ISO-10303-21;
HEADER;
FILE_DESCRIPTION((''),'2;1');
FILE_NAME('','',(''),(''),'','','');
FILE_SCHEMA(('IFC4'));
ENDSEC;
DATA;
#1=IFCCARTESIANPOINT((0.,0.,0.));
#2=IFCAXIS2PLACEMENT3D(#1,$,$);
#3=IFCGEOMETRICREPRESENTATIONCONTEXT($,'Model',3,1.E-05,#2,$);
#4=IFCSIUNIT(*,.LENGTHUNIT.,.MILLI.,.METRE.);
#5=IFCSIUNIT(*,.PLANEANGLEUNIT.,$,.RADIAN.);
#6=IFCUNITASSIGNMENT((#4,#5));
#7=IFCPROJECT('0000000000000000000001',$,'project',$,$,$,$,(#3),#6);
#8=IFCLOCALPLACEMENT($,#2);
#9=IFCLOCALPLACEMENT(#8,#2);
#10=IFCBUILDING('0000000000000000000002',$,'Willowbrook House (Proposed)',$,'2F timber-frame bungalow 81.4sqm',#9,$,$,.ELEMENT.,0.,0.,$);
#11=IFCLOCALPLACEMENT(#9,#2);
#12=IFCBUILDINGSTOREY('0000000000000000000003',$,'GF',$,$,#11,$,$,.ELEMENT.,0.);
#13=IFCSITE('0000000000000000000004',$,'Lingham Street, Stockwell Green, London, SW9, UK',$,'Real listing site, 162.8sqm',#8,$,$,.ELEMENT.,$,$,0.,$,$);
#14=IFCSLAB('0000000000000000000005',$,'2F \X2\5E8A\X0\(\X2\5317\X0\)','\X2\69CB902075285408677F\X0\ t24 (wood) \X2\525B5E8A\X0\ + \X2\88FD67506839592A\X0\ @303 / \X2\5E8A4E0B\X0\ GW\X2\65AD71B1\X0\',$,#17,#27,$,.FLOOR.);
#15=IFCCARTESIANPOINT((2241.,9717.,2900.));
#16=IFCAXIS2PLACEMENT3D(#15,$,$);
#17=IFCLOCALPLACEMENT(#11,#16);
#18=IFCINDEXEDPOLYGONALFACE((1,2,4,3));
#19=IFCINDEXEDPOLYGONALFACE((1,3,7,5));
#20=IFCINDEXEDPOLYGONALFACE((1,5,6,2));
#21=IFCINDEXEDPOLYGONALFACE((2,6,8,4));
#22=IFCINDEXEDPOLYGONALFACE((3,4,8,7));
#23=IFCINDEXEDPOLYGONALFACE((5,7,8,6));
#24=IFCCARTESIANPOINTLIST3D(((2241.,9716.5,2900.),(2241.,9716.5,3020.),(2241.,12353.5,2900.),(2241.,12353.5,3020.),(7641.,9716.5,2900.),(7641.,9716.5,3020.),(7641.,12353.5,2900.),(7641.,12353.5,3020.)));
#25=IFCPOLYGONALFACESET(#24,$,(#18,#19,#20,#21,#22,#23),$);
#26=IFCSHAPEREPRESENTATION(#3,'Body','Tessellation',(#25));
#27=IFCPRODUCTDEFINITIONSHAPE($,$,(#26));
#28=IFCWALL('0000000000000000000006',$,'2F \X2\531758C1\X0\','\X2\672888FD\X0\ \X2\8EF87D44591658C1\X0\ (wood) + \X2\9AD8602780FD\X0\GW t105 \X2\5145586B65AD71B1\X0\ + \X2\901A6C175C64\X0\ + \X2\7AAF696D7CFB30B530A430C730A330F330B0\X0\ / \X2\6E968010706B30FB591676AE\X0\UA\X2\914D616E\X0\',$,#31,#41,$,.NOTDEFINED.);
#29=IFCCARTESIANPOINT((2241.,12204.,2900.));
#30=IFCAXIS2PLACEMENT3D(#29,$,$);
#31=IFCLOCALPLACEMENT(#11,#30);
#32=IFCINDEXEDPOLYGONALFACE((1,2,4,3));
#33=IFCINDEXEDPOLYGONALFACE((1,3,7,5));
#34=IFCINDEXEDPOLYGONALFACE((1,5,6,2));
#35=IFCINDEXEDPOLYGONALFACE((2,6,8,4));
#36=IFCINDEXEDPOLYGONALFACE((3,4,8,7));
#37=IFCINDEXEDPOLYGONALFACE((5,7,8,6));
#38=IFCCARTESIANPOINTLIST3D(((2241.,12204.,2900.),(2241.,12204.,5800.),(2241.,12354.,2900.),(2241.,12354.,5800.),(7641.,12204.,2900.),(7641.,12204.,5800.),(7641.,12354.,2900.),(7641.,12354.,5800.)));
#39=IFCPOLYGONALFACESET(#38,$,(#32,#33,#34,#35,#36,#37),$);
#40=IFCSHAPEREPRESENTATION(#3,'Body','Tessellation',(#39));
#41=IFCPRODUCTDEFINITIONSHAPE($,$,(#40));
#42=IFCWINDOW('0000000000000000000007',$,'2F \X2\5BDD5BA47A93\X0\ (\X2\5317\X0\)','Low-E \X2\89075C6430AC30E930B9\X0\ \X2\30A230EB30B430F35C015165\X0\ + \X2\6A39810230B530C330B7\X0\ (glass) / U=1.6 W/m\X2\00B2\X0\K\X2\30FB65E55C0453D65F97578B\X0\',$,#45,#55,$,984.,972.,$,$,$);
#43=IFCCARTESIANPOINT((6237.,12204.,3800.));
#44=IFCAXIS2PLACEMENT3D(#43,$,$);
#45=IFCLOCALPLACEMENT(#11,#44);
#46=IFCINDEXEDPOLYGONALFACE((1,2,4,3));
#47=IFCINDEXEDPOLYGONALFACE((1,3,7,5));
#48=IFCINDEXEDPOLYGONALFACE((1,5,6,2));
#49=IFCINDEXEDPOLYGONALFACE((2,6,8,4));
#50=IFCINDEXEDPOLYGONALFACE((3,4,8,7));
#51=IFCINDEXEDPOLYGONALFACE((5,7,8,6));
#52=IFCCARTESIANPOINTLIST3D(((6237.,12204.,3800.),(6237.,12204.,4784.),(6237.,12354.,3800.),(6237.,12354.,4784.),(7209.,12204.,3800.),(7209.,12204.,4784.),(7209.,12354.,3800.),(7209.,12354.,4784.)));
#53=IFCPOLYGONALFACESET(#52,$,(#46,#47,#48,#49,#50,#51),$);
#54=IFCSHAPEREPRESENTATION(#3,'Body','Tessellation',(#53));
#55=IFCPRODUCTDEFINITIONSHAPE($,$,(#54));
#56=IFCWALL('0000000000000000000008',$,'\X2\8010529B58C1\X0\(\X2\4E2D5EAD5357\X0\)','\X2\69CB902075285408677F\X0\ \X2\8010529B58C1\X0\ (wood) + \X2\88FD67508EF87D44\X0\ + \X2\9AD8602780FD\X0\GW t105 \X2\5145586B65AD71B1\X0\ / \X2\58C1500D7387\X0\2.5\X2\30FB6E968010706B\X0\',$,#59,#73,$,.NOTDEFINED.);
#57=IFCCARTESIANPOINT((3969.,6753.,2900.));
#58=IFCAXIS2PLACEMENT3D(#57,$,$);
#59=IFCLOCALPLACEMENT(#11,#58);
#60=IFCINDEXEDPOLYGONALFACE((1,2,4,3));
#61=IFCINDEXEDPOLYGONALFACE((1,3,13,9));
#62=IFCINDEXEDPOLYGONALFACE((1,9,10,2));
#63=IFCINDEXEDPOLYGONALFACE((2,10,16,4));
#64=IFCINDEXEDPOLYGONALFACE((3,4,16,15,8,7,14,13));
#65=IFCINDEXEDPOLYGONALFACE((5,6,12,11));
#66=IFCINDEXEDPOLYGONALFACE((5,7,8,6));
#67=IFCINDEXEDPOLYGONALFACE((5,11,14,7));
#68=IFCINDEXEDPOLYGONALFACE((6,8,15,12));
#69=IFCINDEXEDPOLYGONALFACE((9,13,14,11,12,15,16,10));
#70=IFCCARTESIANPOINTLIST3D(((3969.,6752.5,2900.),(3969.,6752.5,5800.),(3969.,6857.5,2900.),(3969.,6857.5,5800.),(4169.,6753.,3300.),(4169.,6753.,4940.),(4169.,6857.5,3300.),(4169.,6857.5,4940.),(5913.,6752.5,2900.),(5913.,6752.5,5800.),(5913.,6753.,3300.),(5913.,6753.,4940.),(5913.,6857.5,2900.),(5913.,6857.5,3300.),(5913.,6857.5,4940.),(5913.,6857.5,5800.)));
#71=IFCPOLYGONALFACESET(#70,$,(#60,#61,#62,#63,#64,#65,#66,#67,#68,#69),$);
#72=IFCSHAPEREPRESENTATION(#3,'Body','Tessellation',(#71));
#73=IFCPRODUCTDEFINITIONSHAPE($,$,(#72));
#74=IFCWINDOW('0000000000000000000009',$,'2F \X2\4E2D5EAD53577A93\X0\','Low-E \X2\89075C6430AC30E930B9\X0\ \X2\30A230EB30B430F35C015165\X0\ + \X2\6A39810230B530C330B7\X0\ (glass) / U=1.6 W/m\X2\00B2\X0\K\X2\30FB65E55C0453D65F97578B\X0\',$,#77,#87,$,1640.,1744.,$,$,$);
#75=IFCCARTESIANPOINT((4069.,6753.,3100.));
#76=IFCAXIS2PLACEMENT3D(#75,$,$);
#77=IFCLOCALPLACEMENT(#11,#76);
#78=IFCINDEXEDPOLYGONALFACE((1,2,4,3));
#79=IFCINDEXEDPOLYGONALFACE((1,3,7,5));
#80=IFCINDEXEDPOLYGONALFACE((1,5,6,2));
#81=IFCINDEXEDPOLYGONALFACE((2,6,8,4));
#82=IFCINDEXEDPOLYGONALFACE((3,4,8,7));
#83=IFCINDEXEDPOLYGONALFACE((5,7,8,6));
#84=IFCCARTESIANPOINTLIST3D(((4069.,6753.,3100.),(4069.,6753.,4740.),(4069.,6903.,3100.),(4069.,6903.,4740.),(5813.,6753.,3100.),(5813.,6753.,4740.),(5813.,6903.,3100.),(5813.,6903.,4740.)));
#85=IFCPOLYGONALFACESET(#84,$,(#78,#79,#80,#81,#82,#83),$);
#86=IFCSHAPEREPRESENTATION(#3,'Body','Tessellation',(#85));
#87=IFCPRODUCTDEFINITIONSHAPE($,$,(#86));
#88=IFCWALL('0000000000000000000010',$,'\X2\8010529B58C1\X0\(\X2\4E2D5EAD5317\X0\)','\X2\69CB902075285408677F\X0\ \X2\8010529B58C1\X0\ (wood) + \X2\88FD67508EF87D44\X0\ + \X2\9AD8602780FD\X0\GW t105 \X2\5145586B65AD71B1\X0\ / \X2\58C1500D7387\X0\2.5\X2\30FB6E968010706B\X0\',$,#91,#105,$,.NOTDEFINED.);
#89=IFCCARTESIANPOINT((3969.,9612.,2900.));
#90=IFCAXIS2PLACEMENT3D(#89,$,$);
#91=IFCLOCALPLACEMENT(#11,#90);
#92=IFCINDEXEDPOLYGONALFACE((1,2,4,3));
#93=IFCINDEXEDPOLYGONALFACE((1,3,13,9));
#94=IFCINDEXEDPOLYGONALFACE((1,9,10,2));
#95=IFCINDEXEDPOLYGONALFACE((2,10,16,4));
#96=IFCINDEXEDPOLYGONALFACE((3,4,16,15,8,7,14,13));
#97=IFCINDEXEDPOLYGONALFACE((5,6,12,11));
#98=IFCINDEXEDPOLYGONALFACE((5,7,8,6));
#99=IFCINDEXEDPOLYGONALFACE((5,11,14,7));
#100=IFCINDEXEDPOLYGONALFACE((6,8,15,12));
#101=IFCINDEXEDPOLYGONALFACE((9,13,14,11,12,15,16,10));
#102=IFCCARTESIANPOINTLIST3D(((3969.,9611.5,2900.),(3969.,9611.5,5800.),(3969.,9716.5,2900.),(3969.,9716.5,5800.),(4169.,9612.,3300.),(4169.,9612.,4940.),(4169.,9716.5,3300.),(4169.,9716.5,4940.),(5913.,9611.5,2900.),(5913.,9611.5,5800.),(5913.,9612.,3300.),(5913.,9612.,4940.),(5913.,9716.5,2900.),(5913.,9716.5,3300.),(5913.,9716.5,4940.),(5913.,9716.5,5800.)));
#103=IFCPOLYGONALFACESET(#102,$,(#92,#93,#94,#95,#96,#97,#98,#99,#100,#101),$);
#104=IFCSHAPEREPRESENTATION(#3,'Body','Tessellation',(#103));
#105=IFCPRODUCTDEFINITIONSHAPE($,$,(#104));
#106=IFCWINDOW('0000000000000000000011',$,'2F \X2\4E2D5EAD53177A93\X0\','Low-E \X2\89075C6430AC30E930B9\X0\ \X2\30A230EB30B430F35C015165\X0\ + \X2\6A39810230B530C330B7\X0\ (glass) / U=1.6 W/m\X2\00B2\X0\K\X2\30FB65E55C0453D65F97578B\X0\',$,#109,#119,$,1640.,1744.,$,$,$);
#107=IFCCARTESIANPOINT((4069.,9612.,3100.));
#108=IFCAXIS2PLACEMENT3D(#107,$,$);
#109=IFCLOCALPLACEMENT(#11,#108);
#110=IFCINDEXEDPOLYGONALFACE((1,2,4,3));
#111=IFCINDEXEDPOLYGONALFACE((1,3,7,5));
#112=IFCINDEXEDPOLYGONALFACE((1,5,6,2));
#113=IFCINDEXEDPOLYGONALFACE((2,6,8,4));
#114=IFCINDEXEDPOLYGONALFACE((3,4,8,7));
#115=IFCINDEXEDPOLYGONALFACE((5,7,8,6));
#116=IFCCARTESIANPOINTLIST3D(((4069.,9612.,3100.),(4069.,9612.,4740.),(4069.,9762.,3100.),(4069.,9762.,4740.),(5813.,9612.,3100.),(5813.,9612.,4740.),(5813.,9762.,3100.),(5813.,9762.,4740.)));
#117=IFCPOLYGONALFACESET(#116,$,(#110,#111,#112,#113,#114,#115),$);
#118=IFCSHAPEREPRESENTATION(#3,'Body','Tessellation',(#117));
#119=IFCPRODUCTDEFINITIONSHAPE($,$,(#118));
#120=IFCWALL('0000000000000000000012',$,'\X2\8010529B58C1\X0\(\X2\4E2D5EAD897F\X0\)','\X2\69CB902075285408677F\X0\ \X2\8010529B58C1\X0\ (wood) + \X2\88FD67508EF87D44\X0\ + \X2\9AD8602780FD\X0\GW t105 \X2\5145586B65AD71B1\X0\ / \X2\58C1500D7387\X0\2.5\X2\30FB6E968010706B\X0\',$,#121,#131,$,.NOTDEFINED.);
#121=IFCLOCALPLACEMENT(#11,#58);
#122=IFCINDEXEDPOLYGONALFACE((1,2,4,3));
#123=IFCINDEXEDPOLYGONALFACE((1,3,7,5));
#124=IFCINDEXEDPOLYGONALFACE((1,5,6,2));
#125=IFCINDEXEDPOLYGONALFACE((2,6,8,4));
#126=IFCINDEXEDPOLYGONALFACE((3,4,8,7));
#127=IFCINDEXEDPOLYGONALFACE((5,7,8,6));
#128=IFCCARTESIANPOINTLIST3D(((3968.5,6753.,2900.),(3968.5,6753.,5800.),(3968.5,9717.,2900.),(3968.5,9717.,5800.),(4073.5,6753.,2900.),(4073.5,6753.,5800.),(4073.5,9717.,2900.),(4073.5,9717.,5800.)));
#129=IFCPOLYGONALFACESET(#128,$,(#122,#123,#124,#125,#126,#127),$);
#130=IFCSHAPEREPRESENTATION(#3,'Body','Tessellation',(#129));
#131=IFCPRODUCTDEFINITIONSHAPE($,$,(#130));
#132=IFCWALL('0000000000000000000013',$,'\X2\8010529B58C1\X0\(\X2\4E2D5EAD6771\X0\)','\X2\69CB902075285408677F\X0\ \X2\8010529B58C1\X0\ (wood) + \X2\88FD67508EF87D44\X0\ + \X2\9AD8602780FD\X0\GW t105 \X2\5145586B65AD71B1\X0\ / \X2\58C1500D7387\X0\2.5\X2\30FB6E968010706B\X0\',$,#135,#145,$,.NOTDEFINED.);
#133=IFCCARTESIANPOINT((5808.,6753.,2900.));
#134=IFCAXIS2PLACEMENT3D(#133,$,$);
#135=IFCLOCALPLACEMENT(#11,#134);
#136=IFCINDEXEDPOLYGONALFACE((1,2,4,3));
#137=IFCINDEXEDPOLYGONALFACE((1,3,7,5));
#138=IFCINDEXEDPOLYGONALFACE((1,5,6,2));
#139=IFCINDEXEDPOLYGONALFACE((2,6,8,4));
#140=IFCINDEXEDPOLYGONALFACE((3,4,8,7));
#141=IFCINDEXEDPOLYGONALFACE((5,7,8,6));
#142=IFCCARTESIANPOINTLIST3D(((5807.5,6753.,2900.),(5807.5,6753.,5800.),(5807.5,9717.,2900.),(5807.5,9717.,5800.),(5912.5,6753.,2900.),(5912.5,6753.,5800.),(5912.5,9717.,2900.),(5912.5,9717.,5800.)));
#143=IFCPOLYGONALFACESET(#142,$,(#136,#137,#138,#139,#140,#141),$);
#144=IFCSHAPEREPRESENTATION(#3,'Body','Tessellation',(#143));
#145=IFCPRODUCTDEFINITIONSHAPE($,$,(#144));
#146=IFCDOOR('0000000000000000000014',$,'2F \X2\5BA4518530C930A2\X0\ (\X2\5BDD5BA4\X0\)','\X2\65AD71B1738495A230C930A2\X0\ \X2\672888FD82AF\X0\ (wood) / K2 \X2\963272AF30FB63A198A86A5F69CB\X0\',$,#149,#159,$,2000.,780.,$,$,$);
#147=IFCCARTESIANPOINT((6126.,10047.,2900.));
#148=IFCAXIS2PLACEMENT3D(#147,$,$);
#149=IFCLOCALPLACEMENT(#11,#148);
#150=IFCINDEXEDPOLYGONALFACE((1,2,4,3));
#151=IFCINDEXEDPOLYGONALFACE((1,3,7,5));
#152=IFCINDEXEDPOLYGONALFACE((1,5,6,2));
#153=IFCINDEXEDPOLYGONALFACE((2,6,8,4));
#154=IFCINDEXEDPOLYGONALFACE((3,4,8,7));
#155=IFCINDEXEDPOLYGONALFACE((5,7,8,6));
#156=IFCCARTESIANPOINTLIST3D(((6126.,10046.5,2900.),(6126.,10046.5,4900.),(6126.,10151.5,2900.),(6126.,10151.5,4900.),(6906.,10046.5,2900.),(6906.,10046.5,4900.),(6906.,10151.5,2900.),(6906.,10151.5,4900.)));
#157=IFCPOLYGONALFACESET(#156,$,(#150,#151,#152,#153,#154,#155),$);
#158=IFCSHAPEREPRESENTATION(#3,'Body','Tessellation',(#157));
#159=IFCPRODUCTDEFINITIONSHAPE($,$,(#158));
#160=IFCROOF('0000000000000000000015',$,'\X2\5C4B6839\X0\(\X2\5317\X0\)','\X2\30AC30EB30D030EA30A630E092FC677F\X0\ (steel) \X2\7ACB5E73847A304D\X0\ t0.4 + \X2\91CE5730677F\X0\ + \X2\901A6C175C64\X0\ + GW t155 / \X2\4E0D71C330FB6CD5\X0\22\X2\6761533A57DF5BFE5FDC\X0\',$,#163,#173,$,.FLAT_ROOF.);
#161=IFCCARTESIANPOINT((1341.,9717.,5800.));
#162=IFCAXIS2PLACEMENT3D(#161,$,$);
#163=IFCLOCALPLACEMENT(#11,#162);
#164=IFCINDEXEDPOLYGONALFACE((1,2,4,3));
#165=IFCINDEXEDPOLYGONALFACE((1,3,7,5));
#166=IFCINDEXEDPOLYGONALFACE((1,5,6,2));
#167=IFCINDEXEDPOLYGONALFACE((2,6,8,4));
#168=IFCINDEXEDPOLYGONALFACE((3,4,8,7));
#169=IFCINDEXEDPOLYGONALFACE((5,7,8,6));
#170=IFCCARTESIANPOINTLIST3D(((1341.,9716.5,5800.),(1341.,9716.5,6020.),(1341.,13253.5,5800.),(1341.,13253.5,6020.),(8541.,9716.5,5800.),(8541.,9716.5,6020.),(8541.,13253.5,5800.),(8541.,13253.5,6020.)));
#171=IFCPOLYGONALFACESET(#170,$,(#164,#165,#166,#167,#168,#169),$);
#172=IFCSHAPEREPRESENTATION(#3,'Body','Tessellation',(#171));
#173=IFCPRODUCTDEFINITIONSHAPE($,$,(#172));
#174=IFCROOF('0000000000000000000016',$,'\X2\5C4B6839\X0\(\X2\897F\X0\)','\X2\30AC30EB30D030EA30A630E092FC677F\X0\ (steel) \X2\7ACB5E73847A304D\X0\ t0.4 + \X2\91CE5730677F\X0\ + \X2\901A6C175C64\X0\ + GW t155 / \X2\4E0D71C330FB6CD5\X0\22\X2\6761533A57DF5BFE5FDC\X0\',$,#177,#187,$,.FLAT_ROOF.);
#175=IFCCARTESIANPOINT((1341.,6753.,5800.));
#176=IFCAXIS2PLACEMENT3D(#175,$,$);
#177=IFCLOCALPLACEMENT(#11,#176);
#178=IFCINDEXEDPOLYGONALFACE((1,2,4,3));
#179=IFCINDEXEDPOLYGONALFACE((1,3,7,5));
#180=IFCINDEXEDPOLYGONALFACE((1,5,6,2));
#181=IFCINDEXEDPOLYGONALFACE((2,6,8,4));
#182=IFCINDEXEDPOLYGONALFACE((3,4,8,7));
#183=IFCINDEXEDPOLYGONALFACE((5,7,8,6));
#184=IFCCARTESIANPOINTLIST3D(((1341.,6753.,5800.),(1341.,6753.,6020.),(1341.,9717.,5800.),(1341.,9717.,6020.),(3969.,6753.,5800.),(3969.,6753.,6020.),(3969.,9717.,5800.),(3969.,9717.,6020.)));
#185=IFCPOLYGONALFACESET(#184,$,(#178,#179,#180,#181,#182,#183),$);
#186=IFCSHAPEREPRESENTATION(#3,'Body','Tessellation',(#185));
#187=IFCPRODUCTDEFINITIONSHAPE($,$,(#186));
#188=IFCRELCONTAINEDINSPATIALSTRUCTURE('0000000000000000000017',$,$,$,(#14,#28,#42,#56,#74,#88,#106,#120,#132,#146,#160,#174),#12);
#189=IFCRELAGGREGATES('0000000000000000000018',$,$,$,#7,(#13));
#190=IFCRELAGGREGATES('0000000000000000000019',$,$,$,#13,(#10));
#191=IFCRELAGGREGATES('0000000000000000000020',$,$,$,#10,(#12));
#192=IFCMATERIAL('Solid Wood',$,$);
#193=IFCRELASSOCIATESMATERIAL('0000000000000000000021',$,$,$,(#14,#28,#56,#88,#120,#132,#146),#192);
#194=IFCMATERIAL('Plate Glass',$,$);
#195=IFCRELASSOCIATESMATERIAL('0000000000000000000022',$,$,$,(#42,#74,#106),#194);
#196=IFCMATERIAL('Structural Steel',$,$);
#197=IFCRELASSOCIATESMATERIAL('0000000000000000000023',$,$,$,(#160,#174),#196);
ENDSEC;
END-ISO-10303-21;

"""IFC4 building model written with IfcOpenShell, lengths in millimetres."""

from ifc_helpers import new_model, si_unit, frame, frame_2d, origin, place, context, project, spatial, rectangle, extrude, material, element, fill, save


model = new_model("IFC4")

# Units and contexts
model_context = context("Model", 3, precision=1e-05, world=origin())
ifc_project = project(units=[si_unit("LENGTHUNIT", "METRE", prefix="MILLI"), si_unit("PLANEANGLEUNIT", "RADIAN")], contexts=[model_context])

# Site, building, storey
site_placement = place(None, origin())
site = spatial("IfcSite", under=ifc_project, at=site_placement, Name="Lingham Street, Stockwell Green, London, SW9, UK", ObjectType="Real listing site, 162.8sqm", CompositionType="ELEMENT", RefElevation=0.0)
building_placement = place(site_placement, origin())
building = spatial("IfcBuilding", under=site, at=building_placement, Name="Willowbrook House (Proposed)", ObjectType="2F timber-frame bungalow 81.4sqm", CompositionType="ELEMENT", ElevationOfRefHeight=0.0, ElevationOfTerrain=0.0)
storey_placement = place(building_placement, origin())
storey = spatial("IfcBuildingStorey", under=building, at=storey_placement, Name="GF", CompositionType="ELEMENT", Elevation=0.0)

# Slab
ifc_material_1 = material(Name="Solid Wood")
slab_placement = place(storey_placement, frame((2241.0, 9717.0, 2900.0)))
element("IfcSlab", 1, at=slab_placement, inside=storey, material=ifc_material_1, Name="2F 床(北)", Description="構造用合板 t24 (wood) 剛床 + 製材根太 @303 / 床下 GW断熱", PredefinedType="FLOOR", context=model_context, shape_type="SweptSolid", body=[
    extrude(rectangle(XDim=5400.0, YDim=2637.0, at=frame_2d((2700.0, 1318.0))), frame((2241.0, 9717.0, 2900.0)), (0.0, 0.0, 1.0), 120.0),
])

# Walls, openings, windows
wall_1_placement = place(storey_placement, frame((2241.0, 12204.0, 2900.0)))
wall_1 = element("IfcWall", 2, at=wall_1_placement, inside=storey, material=ifc_material_1, Name="2F 北壁", Description="木製 軸組外壁 (wood) + 高性能GW t105 充填断熱 + 通気層 + 窯業系サイディング / 準耐火・外皮UA配慮", PredefinedType="NOTDEFINED", context=model_context, shape_type="SweptSolid", body=[
    extrude(rectangle(XDim=5400.0, YDim=150.0, at=frame_2d((2700.0, 75.0))), frame((2241.0, 12204.0, 2900.0)), (0.0, 0.0, 1.0), 2900.0),
])
opening_1_placement = place(storey_placement, frame((6237.0, 12204.0, 3800.0)))
opening_1 = element("IfcOpeningElement", 3, at=opening_1_placement, cuts=wall_1, PredefinedType="NOTDEFINED", context=model_context, shape_type="SweptSolid", body=[
    extrude(rectangle(XDim=972.0, YDim=150.0, at=frame_2d((486.0, 75.0))), frame((6237.0, 12204.0, 3800.0)), (0.0, 0.0, 1.0), 984.0),
])
ifc_material_2 = material(Name="Plate Glass")
window_1_placement = place(storey_placement, frame((6237.0, 12204.0, 3800.0)))
window_1 = element("IfcWindow", 4, at=window_1_placement, inside=storey, material=ifc_material_2, Name="2F 寝室窓 (北)", Description="Low-E 複層ガラス アルゴン封入 + 樹脂サッシ (glass) / U=1.6 W/m²K・日射取得型", OverallHeight=984.0, OverallWidth=972.0, context=model_context, shape_type="SweptSolid", body=[
    extrude(rectangle(XDim=972.0, YDim=150.0, at=frame_2d((486.0, 75.0))), frame((6237.0, 12204.0, 3800.0)), (0.0, 0.0, 1.0), 984.0),
])
fill(opening_1, window_1)
wall_2_placement = place(storey_placement, frame((3969.0, 6753.0, 2900.0)))
wall_2 = element("IfcWall", 5, at=wall_2_placement, inside=storey, material=ifc_material_1, Name="耐力壁(中庭南)", Description="構造用合板 耐力壁 (wood) + 製材軸組 + 高性能GW t105 充填断熱 / 壁倍率2.5・準耐火", PredefinedType="NOTDEFINED", context=model_context, shape_type="SweptSolid", body=[
    extrude(rectangle(XDim=1944.0, YDim=105.0, at=frame_2d((972.0, 52.0))), frame((3969.0, 6753.0, 2900.0)), (0.0, 0.0, 1.0), 2900.0),
])
opening_2_placement = place(storey_placement, frame((4069.0, 6753.0, 3100.0)))
opening_2 = element("IfcOpeningElement", 6, at=opening_2_placement, cuts=wall_2, PredefinedType="NOTDEFINED", context=model_context, shape_type="SweptSolid", body=[
    extrude(rectangle(XDim=1744.0, YDim=150.0, at=frame_2d((872.0, 75.0))), frame((4069.0, 6753.0, 3100.0)), (0.0, 0.0, 1.0), 1640.0),
])
window_2_placement = place(storey_placement, frame((4069.0, 6753.0, 3100.0)))
window_2 = element("IfcWindow", 7, at=window_2_placement, inside=storey, material=ifc_material_2, Name="2F 中庭南窓", Description="Low-E 複層ガラス アルゴン封入 + 樹脂サッシ (glass) / U=1.6 W/m²K・日射取得型", OverallHeight=1640.0, OverallWidth=1744.0, context=model_context, shape_type="SweptSolid", body=[
    extrude(rectangle(XDim=1744.0, YDim=150.0, at=frame_2d((872.0, 75.0))), frame((4069.0, 6753.0, 3100.0)), (0.0, 0.0, 1.0), 1640.0),
])
fill(opening_2, window_2)
wall_3_placement = place(storey_placement, frame((3969.0, 9612.0, 2900.0)))
wall_3 = element("IfcWall", 8, at=wall_3_placement, inside=storey, material=ifc_material_1, Name="耐力壁(中庭北)", Description="構造用合板 耐力壁 (wood) + 製材軸組 + 高性能GW t105 充填断熱 / 壁倍率2.5・準耐火", PredefinedType="NOTDEFINED", context=model_context, shape_type="SweptSolid", body=[
    extrude(rectangle(XDim=1944.0, YDim=105.0, at=frame_2d((972.0, 52.0))), frame((3969.0, 9612.0, 2900.0)), (0.0, 0.0, 1.0), 2900.0),
])
opening_3_placement = place(storey_placement, frame((4069.0, 9612.0, 3100.0)))
opening_3 = element("IfcOpeningElement", 9, at=opening_3_placement, cuts=wall_3, PredefinedType="NOTDEFINED", context=model_context, shape_type="SweptSolid", body=[
    extrude(rectangle(XDim=1744.0, YDim=150.0, at=frame_2d((872.0, 75.0))), frame((4069.0, 9612.0, 3100.0)), (0.0, 0.0, 1.0), 1640.0),
])
window_3_placement = place(storey_placement, frame((4069.0, 9612.0, 3100.0)))
window_3 = element("IfcWindow", 10, at=window_3_placement, inside=storey, material=ifc_material_2, Name="2F 中庭北窓", Description="Low-E 複層ガラス アルゴン封入 + 樹脂サッシ (glass) / U=1.6 W/m²K・日射取得型", OverallHeight=1640.0, OverallWidth=1744.0, context=model_context, shape_type="SweptSolid", body=[
    extrude(rectangle(XDim=1744.0, YDim=150.0, at=frame_2d((872.0, 75.0))), frame((4069.0, 9612.0, 3100.0)), (0.0, 0.0, 1.0), 1640.0),
])
fill(opening_3, window_3)

# Walls
wall_4_placement = place(storey_placement, frame((3969.0, 6753.0, 2900.0)))
element("IfcWall", 11, at=wall_4_placement, inside=storey, material=ifc_material_1, Name="耐力壁(中庭西)", Description="構造用合板 耐力壁 (wood) + 製材軸組 + 高性能GW t105 充填断熱 / 壁倍率2.5・準耐火", PredefinedType="NOTDEFINED", context=model_context, shape_type="SweptSolid", body=[
    extrude(rectangle(XDim=105.0, YDim=2964.0, at=frame_2d((52.0, 1482.0))), frame((3969.0, 6753.0, 2900.0)), (0.0, 0.0, 1.0), 2900.0),
])
wall_5_placement = place(storey_placement, frame((5808.0, 6753.0, 2900.0)))
element("IfcWall", 12, at=wall_5_placement, inside=storey, material=ifc_material_1, Name="耐力壁(中庭東)", Description="構造用合板 耐力壁 (wood) + 製材軸組 + 高性能GW t105 充填断熱 / 壁倍率2.5・準耐火", PredefinedType="NOTDEFINED", context=model_context, shape_type="SweptSolid", body=[
    extrude(rectangle(XDim=105.0, YDim=2964.0, at=frame_2d((52.0, 1482.0))), frame((5808.0, 6753.0, 2900.0)), (0.0, 0.0, 1.0), 2900.0),
])

# Door
door_placement = place(storey_placement, frame((6126.0, 10047.0, 2900.0)))
element("IfcDoor", 13, at=door_placement, inside=storey, material=ifc_material_1, Name="2F 室内ドア (寝室)", Description="断熱玄関ドア 木製芯 (wood) / K2 防犯・採風機構", OverallHeight=2000.0, OverallWidth=780.0, context=model_context, shape_type="SweptSolid", body=[
    extrude(rectangle(XDim=780.0, YDim=105.0, at=frame_2d((390.0, 52.0))), frame((6126.0, 10047.0, 2900.0)), (0.0, 0.0, 1.0), 2000.0),
])

# Roofs
ifc_material_3 = material(Name="Structural Steel")
for number, where, name in (
    (14, (1341.0, 9717.0, 5800.0), "屋根(北)"),
):
    element("IfcRoof", number, at=place(storey_placement, frame(where)), inside=storey, material=ifc_material_3, Name=name, Description="ガルバリウム鋼板 (steel) 立平葺き t0.4 + 野地板 + 通気層 + GW t155 / 不燃・法22条区域対応", PredefinedType="FLAT_ROOF", context=model_context, shape_type="SweptSolid", body=[
        extrude(rectangle(XDim=7200.0, YDim=3537.0, at=frame_2d((3600.0, 1768.0))), frame((1341.0, 9717.0, 5800.0)), (0.0, 0.0, 1.0), 220.0),
    ])
roof_1_placement = place(storey_placement, frame((1341.0, 6753.0, 5800.0)))
element("IfcRoof", 15, at=roof_1_placement, inside=storey, material=ifc_material_3, Name="屋根(西)", Description="ガルバリウム鋼板 (steel) 立平葺き t0.4 + 野地板 + 通気層 + GW t155 / 不燃・法22条区域対応", PredefinedType="FLAT_ROOF", context=model_context, shape_type="SweptSolid", body=[
    extrude(rectangle(XDim=2628.0, YDim=2964.0, at=frame_2d((1314.0, 1482.0))), frame((1341.0, 6753.0, 5800.0)), (0.0, 0.0, 1.0), 220.0),
])

save(model, "model.ifc")
